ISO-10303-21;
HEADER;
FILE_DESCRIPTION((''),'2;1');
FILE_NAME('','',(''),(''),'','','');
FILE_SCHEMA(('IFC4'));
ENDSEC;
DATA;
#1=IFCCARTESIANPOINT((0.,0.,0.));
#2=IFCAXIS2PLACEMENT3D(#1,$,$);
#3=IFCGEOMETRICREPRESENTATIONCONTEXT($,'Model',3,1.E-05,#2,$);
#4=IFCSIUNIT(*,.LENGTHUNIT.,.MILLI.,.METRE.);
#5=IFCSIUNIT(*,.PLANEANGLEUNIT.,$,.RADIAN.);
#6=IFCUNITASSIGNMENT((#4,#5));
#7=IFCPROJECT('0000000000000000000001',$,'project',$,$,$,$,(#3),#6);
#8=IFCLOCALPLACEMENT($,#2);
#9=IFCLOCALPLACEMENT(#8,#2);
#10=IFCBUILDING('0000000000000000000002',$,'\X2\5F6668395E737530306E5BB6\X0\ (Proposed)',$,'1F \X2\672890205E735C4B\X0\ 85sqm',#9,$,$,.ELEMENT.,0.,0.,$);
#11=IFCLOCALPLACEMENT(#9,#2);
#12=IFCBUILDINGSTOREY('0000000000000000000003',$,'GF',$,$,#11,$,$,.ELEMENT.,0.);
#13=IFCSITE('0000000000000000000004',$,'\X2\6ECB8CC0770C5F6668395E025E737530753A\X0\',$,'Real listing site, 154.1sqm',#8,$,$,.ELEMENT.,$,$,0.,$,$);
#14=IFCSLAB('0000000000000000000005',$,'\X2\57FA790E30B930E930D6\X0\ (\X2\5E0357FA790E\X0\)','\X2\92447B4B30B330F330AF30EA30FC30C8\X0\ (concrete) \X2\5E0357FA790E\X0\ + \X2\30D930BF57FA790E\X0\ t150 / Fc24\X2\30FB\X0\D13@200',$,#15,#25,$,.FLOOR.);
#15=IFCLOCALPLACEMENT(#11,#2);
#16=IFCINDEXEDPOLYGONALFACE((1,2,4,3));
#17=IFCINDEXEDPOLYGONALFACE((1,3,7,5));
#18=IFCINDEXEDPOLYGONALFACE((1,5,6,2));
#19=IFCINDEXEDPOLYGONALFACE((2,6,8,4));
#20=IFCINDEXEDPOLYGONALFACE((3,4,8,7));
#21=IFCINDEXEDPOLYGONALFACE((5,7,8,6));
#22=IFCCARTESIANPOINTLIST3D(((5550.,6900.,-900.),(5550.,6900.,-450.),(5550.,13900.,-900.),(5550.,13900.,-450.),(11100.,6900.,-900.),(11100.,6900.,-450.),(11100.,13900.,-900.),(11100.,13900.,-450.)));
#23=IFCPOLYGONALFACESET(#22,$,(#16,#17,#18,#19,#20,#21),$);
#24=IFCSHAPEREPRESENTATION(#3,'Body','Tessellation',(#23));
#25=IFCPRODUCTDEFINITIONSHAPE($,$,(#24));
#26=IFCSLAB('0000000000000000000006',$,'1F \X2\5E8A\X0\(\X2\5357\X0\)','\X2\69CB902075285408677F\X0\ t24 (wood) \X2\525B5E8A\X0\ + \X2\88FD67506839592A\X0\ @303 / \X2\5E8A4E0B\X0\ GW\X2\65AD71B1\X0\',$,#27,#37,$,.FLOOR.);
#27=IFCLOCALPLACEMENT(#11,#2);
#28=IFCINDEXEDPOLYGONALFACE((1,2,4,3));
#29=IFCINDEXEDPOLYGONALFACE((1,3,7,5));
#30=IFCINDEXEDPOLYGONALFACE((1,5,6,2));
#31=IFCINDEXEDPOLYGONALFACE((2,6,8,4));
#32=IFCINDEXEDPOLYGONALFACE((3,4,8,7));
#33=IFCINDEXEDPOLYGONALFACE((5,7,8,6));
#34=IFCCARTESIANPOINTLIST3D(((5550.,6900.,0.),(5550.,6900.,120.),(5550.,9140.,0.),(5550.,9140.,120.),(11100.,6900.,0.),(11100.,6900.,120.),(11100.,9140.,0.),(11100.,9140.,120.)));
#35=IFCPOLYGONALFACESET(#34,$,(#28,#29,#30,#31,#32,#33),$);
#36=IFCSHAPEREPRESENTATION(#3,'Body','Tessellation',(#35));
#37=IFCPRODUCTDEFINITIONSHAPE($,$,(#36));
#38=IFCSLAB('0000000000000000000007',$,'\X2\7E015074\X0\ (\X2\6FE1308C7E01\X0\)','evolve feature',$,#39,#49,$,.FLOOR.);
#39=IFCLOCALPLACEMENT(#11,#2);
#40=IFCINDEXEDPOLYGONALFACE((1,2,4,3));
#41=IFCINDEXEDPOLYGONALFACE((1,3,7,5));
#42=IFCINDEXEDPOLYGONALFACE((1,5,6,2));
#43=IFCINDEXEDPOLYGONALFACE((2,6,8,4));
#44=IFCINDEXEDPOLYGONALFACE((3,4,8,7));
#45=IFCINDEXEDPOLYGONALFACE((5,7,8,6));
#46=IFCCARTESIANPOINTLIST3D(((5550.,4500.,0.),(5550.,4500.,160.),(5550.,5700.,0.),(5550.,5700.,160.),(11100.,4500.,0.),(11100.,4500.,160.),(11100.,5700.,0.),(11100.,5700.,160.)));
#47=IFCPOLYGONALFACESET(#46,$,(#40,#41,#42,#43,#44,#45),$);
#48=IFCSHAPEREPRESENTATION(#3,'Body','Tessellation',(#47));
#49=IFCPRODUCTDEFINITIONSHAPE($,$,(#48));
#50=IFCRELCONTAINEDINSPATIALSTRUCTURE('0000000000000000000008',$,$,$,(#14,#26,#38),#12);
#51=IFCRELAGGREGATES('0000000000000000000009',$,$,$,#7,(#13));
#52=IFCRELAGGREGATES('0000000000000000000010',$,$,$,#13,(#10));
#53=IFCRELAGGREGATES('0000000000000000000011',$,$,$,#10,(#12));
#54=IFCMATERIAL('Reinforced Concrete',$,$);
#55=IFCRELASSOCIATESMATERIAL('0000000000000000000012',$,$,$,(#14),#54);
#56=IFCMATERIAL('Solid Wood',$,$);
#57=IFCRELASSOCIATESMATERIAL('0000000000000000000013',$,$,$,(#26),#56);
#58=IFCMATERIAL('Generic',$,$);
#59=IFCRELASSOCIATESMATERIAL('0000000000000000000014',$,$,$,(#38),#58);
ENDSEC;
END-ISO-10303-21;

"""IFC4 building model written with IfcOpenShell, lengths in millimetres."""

from ifc_helpers import new_model, si_unit, frame, frame_2d, origin, place, context, project, spatial, rectangle, extrude, material, element, save


model = new_model("IFC4")

# Units and contexts
model_context = context("Model", 3, precision=1e-05, world=origin())
ifc_project = project(units=[si_unit("LENGTHUNIT", "METRE", prefix="MILLI"), si_unit("PLANEANGLEUNIT", "RADIAN")], contexts=[model_context])

# Site, building, storey
site_placement = place(None, origin())
site = spatial("IfcSite", under=ifc_project, at=site_placement, Name="滋賀県彦根市平田町", ObjectType="Real listing site, 154.1sqm", CompositionType="ELEMENT", RefElevation=0.0)
building_placement = place(site_placement, origin())
building = spatial("IfcBuilding", under=site, at=building_placement, Name="彦根平田の家 (Proposed)", ObjectType="1F 木造平屋 85sqm", CompositionType="ELEMENT", ElevationOfRefHeight=0.0, ElevationOfTerrain=0.0)
storey_placement = place(building_placement, origin())
storey = spatial("IfcBuildingStorey", under=building, at=storey_placement, Name="GF", CompositionType="ELEMENT", Elevation=0.0)

# Slabs
ifc_material_1 = material(Name="Reinforced Concrete")
slab_1_placement = place(storey_placement, frame((2775.0, 3450.0, -450.0)))
element("IfcSlab", 1, at=slab_1_placement, inside=storey, material=ifc_material_1, Name="基礎スラブ (布基礎)", Description="鉄筋コンクリート (concrete) 布基礎 + ベタ基礎 t150 / Fc24・D13@200", PredefinedType="FLOOR", context=model_context, shape_type="SweptSolid", body=[
    extrude(rectangle(XDim=5550.0, YDim=7000.0, at=frame_2d((2775.0, 3500.0))), frame((2775.0, 3450.0, -450.0)), (0.0, 0.0, 1.0), 450.0),
])
ifc_material_2 = material(Name="Solid Wood")
slab_2_placement = place(storey_placement, frame((2775.0, 3450.0, 0.0)))
element("IfcSlab", 2, at=slab_2_placement, inside=storey, material=ifc_material_2, Name="1F 床(南)", Description="構造用合板 t24 (wood) 剛床 + 製材根太 @303 / 床下 GW断熱", PredefinedType="FLOOR", context=model_context, shape_type="SweptSolid", body=[
    extrude(rectangle(XDim=5550.0, YDim=2240.0, at=frame_2d((2775.0, 1120.0))), frame((2775.0, 3450.0, 0.0)), (0.0, 0.0, 1.0), 120.0),
])
ifc_material_3 = material(Name="Generic")
slab_3_placement = place(storey_placement, frame((2775.0, 2250.0, 0.0)))
element("IfcSlab", 3, at=slab_3_placement, inside=storey, material=ifc_material_3, Name="縁側 (濡れ縁)", Description="evolve feature", PredefinedType="FLOOR", context=model_context, shape_type="SweptSolid", body=[
    extrude(rectangle(XDim=5550.0, YDim=1200.0, at=frame_2d((2775.0, 600.0))), frame((2775.0, 2250.0, 0.0)), (0.0, 0.0, 1.0), 160.0),
])

save(model, "model.ifc")
